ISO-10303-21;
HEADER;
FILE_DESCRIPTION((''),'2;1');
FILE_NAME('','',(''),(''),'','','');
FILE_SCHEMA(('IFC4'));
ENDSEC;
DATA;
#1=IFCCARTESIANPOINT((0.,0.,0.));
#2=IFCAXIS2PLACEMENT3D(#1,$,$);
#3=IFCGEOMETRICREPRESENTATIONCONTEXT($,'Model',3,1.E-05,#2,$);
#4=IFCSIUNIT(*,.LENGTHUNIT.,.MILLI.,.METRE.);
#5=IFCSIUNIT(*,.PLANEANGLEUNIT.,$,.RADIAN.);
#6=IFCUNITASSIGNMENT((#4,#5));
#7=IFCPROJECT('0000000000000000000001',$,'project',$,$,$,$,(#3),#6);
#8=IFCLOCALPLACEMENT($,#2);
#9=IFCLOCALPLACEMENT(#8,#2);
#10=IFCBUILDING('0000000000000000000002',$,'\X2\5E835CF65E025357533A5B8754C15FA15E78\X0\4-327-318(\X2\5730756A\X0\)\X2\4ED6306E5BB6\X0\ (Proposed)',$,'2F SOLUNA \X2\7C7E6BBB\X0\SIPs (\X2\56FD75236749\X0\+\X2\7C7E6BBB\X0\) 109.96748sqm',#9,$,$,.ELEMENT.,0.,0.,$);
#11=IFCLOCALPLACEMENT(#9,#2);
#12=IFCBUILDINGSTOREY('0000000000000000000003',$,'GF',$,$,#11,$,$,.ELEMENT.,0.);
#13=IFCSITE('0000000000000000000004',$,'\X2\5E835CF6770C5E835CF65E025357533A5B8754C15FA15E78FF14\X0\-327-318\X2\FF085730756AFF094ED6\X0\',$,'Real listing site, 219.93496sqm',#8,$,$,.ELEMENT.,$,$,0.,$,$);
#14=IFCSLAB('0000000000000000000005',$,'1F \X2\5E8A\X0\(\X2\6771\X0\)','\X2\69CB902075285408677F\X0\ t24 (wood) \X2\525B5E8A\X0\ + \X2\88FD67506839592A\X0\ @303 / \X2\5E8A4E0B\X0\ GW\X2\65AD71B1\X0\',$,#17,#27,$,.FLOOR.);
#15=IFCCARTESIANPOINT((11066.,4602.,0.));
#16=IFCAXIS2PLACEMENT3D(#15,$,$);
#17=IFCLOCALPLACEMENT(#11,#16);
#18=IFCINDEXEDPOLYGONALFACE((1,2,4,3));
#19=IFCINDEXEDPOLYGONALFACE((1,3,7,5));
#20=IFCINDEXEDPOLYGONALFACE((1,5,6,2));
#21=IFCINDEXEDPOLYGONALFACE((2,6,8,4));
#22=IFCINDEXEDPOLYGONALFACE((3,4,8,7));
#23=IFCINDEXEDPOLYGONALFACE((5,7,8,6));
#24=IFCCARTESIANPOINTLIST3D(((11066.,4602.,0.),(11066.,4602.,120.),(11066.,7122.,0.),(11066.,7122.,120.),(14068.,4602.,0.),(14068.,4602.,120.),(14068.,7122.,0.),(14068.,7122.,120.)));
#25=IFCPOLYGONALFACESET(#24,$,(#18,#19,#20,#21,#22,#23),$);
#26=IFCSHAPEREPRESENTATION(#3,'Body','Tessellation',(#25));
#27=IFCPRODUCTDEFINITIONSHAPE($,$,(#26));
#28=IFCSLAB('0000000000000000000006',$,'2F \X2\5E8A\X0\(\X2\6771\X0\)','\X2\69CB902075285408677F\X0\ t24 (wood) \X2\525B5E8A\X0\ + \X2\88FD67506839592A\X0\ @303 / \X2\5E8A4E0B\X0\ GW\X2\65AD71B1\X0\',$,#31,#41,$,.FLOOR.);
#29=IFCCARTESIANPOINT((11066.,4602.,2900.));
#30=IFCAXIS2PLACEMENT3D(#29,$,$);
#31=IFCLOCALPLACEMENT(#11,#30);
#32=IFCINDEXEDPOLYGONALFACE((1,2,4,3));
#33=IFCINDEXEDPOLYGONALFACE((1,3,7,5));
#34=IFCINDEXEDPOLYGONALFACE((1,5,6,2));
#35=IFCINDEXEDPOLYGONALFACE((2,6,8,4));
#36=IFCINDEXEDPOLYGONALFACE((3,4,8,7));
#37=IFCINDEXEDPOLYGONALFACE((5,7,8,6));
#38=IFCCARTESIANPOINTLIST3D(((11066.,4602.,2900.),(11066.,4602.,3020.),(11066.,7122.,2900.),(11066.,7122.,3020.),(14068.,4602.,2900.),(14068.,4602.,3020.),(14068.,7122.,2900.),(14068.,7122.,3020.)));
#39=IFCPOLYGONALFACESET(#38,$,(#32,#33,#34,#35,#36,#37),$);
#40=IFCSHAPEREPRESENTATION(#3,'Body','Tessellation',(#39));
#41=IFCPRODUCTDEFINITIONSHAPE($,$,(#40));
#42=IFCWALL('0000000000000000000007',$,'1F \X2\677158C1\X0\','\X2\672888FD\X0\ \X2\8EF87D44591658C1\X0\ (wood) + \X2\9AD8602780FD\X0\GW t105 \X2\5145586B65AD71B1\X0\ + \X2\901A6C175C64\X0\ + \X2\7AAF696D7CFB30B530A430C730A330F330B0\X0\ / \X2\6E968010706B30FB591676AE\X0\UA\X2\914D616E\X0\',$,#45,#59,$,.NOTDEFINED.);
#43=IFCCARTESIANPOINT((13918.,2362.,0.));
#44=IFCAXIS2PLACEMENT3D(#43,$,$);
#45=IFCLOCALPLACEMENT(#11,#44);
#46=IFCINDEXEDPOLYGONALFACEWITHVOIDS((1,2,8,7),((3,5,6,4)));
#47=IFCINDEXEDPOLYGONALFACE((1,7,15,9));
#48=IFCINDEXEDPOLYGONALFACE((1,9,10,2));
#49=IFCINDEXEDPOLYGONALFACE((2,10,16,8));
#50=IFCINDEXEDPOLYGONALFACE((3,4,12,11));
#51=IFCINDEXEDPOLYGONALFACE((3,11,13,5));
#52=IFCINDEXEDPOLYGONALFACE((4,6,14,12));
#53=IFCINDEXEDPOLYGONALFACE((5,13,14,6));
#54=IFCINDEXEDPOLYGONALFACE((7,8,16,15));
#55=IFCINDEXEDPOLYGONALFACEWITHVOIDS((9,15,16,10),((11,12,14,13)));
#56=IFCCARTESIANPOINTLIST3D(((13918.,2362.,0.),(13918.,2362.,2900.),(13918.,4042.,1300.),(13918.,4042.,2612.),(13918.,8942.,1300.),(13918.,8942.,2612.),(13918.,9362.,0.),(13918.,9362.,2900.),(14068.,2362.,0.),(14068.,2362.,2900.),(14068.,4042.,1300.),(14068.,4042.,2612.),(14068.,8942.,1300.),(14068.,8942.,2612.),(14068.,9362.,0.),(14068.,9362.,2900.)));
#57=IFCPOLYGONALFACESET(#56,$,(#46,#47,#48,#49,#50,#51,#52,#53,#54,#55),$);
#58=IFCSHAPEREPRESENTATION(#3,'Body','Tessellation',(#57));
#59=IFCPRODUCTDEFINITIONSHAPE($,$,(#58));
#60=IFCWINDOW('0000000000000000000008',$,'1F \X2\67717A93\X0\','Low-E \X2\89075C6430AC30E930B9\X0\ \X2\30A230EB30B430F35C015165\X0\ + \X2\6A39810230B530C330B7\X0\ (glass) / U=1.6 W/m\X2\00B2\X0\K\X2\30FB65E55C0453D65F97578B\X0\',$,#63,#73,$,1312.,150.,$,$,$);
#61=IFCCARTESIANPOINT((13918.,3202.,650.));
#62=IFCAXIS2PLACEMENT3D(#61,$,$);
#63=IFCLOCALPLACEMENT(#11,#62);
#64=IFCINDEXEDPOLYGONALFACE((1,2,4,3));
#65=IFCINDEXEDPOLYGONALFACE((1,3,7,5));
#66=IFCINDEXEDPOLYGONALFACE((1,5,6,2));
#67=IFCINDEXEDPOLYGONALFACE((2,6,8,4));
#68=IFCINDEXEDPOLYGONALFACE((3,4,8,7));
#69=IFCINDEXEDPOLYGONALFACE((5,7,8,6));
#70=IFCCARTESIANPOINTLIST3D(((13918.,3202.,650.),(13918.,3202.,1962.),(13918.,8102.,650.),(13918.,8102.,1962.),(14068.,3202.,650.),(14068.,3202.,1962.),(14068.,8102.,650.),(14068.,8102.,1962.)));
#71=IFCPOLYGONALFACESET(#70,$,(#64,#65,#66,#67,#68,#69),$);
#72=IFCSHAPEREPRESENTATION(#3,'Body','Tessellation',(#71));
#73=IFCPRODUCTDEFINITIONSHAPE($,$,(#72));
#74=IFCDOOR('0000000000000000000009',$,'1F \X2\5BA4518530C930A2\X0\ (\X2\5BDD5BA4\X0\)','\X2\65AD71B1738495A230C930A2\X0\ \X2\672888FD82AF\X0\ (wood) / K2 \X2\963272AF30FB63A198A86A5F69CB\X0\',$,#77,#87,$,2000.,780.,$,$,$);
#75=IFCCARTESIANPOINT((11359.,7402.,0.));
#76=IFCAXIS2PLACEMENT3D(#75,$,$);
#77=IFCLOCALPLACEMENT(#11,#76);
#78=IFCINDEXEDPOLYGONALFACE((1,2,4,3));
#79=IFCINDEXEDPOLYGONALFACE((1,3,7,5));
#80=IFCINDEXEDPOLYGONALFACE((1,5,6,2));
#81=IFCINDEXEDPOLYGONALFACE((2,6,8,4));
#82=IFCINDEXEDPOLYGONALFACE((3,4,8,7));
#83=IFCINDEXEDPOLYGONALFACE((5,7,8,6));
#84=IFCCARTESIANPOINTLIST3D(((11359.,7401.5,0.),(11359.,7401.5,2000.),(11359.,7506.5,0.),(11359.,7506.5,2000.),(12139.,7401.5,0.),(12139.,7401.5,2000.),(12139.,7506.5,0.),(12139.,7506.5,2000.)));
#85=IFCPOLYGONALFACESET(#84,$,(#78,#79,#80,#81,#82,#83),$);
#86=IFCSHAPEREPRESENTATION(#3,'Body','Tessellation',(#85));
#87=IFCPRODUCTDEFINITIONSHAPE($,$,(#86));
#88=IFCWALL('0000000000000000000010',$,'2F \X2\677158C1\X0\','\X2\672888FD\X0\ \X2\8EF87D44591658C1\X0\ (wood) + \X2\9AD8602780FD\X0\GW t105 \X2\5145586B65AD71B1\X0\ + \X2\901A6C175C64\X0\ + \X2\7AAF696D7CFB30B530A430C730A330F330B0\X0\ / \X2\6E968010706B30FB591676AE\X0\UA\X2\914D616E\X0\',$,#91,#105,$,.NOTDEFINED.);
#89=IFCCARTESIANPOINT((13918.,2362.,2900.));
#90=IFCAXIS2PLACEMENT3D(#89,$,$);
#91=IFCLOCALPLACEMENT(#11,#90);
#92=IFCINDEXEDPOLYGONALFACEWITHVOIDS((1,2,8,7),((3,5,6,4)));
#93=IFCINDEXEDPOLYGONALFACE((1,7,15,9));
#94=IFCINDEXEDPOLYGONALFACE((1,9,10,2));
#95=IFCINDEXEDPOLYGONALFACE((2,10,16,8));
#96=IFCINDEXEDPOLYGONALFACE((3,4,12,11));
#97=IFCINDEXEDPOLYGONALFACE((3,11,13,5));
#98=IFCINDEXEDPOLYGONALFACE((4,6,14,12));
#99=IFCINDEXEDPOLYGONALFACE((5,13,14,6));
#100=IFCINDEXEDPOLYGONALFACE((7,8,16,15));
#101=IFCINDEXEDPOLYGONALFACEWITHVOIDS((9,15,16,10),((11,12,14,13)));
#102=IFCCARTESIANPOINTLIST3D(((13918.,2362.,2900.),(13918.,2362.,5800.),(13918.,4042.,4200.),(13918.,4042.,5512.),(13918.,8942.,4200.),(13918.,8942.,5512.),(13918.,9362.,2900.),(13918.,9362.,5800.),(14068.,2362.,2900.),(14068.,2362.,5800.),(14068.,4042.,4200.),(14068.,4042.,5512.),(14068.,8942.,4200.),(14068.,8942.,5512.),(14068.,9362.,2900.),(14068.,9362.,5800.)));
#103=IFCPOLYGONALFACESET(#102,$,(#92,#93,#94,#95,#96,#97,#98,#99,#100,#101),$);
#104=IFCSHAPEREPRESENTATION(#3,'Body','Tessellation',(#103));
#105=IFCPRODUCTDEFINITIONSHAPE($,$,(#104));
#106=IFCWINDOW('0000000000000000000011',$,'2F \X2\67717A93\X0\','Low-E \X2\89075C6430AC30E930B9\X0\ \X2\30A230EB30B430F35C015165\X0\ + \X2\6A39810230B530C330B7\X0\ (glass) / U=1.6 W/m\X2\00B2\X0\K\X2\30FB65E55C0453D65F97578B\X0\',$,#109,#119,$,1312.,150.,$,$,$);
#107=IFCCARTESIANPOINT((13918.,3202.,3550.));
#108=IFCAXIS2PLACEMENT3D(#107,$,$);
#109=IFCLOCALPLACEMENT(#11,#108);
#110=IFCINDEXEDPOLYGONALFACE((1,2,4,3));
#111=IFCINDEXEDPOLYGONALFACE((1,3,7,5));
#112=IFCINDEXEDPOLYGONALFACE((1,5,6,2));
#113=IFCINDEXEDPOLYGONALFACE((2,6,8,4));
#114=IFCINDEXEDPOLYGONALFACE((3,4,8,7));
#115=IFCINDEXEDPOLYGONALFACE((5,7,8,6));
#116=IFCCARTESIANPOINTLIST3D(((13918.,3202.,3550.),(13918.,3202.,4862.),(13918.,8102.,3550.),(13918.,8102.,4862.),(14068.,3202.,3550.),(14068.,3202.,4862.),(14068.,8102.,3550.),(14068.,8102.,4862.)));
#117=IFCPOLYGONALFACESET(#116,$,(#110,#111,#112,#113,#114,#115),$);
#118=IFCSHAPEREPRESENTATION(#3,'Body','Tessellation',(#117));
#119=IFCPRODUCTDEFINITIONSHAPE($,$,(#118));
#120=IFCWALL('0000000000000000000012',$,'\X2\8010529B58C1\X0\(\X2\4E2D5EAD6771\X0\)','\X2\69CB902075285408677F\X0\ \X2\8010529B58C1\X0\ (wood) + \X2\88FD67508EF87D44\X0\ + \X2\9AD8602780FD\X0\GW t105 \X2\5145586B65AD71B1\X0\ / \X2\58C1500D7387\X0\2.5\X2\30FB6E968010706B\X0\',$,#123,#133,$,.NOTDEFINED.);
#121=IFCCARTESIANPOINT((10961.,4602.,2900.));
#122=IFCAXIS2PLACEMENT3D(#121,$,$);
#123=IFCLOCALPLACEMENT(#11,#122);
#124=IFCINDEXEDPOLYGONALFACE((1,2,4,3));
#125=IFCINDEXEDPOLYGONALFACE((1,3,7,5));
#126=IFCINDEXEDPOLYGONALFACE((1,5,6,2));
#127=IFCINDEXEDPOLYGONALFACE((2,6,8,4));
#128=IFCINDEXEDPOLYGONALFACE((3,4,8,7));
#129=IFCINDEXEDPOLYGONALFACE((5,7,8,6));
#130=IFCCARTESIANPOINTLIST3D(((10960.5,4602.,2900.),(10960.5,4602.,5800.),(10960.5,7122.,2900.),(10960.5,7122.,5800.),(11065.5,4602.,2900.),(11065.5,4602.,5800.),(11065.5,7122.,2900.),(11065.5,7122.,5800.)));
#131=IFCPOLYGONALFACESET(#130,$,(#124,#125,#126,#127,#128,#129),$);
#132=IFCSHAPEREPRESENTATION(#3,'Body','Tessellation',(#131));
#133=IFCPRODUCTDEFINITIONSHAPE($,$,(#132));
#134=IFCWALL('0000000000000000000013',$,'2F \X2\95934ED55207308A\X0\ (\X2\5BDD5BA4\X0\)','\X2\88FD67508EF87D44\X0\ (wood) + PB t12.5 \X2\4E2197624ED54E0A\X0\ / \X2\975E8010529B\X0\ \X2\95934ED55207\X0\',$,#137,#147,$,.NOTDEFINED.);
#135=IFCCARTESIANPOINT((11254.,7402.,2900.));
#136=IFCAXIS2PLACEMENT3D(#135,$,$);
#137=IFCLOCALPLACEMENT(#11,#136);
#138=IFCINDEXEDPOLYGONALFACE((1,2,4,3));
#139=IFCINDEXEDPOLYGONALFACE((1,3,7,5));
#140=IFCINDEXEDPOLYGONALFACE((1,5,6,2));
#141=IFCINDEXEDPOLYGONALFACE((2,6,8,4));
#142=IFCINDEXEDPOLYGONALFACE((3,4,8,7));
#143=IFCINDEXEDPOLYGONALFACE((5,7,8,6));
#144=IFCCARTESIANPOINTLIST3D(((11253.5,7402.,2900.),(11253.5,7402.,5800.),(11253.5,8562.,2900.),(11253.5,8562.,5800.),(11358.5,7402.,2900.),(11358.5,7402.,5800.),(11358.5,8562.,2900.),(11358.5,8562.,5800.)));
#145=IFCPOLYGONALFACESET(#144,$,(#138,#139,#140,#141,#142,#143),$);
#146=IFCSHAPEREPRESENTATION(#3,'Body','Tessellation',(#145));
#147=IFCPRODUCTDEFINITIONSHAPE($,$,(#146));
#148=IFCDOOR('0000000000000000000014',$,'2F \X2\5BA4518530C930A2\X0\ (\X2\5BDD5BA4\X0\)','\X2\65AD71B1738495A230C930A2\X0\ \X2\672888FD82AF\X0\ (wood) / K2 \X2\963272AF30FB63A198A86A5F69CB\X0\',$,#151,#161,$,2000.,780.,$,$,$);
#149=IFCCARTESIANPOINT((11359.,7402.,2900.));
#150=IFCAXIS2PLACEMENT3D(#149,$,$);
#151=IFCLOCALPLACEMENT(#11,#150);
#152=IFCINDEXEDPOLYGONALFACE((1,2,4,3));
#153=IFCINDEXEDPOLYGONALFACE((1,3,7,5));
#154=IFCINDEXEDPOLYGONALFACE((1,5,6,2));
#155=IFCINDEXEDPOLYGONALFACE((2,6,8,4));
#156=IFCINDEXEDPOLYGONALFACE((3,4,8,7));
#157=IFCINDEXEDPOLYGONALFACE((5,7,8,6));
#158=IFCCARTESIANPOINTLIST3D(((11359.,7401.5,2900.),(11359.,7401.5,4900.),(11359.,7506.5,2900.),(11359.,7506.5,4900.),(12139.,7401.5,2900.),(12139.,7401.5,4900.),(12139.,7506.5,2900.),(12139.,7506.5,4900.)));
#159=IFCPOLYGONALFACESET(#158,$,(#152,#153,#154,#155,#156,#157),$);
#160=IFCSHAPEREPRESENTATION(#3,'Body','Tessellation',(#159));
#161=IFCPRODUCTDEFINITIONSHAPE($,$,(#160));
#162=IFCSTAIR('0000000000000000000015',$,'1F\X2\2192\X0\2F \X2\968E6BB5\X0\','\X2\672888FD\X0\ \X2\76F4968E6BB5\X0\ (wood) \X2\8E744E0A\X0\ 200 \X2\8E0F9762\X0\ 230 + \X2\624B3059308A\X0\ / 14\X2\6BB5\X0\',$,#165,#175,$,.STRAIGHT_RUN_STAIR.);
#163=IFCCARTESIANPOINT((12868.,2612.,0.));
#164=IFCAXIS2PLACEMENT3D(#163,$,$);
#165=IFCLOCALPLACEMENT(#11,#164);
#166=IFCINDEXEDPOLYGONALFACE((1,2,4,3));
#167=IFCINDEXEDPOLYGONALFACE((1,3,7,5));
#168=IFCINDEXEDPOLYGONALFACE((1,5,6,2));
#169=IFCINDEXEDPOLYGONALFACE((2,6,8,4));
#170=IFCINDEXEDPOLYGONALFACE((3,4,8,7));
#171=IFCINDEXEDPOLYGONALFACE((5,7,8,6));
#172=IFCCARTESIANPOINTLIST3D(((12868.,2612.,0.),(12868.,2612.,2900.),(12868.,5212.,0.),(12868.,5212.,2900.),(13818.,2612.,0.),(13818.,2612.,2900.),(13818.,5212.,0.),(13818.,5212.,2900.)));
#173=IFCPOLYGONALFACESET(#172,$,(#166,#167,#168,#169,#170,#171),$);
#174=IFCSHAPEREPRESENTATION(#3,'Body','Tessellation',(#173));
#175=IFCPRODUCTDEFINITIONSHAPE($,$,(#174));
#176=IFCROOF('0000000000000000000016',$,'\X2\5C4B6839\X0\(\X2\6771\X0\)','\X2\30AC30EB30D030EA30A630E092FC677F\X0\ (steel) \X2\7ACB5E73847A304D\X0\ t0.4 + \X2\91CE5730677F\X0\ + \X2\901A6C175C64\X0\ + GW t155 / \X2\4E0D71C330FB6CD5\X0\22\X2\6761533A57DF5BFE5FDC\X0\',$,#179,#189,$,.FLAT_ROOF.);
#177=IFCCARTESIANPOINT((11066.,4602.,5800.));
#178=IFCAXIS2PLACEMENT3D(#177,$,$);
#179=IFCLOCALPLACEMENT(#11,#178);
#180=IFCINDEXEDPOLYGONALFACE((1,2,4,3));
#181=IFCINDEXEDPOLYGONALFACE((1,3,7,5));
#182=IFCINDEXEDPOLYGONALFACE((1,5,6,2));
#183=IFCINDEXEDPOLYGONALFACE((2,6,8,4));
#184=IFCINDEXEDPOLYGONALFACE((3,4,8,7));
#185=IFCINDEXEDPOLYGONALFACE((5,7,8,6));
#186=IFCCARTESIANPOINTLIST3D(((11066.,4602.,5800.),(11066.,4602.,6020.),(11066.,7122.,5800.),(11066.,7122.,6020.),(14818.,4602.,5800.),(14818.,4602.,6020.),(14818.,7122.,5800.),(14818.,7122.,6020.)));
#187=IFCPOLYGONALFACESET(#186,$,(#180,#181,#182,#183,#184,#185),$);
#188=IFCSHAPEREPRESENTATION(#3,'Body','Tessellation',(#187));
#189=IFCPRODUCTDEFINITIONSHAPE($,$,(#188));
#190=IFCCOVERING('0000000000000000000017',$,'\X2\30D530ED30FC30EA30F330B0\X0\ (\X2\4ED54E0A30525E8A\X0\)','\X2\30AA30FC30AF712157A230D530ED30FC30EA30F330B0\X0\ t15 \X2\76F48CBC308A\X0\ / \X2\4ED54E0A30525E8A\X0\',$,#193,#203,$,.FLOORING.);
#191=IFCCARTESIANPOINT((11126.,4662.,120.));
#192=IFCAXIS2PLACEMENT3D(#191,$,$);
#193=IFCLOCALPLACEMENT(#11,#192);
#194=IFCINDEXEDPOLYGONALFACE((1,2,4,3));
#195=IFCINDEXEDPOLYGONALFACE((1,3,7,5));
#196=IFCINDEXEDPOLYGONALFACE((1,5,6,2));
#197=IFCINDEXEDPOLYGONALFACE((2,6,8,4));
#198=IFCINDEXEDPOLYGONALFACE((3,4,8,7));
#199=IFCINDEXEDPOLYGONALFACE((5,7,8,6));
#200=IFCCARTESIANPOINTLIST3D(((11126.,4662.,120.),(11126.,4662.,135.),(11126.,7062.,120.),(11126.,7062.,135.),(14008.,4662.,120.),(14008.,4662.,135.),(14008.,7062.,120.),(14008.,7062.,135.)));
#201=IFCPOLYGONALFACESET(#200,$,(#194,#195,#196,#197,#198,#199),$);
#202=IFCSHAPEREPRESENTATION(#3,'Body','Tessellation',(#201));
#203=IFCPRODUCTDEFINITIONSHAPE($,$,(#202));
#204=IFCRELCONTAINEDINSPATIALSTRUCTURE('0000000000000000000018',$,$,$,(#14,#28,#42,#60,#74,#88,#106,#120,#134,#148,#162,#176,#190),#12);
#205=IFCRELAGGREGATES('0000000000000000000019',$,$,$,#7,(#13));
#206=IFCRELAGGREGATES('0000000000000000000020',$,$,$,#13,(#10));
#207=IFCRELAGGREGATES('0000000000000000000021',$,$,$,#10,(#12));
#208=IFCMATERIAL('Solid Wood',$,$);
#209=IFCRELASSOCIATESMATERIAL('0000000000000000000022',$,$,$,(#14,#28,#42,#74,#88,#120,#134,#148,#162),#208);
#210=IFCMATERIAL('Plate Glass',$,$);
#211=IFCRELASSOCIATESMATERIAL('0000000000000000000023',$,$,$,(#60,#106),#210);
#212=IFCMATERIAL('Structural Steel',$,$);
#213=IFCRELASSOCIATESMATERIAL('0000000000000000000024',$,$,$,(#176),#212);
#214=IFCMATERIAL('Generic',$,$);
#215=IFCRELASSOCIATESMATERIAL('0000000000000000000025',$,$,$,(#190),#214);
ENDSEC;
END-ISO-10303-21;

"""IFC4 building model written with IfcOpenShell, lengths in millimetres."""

from ifc_helpers import new_model, si_unit, frame, frame_2d, origin, place, context, project, spatial, rectangle, extrude, material, element, fill, save


model = new_model("IFC4")

# Units and contexts
model_context = context("Model", 3, precision=1e-05, world=origin())
ifc_project = project(units=[si_unit("LENGTHUNIT", "METRE", prefix="MILLI"), si_unit("PLANEANGLEUNIT", "RADIAN")], contexts=[model_context])

# Site, building, storey
site_placement = place(None, origin())
site = spatial("IfcSite", under=ifc_project, at=site_placement, Name="広島県広島市南区宇品御幸４-327-318（地番）他", ObjectType="Real listing site, 219.93496sqm", CompositionType="ELEMENT", RefElevation=0.0)
building_placement = place(site_placement, origin())
building = spatial("IfcBuilding", under=site, at=building_placement, Name="広島市南区宇品御幸4-327-318(地番)他の家 (Proposed)", ObjectType="2F SOLUNA 籾殻SIPs (国産杉+籾殻) 109.96748sqm", CompositionType="ELEMENT", ElevationOfRefHeight=0.0, ElevationOfTerrain=0.0)
storey_placement = place(building_placement, origin())
storey = spatial("IfcBuildingStorey", under=building, at=storey_placement, Name="GF", CompositionType="ELEMENT", Elevation=0.0)

# Slabs
ifc_material_1 = material(Name="Solid Wood")
slab_1_placement = place(storey_placement, frame((11066.0, 4602.0, 0.0)))
element("IfcSlab", 1, at=slab_1_placement, inside=storey, material=ifc_material_1, Name="1F 床(東)", Description="構造用合板 t24 (wood) 剛床 + 製材根太 @303 / 床下 GW断熱", PredefinedType="FLOOR", context=model_context, shape_type="SweptSolid", body=[
    extrude(rectangle(XDim=3002.0, YDim=2520.0, at=frame_2d((1501.0, 1260.0))), frame((11066.0, 4602.0, 0.0)), (0.0, 0.0, 1.0), 120.0),
])
slab_2_placement = place(storey_placement, frame((11066.0, 4602.0, 2900.0)))
element("IfcSlab", 2, at=slab_2_placement, inside=storey, material=ifc_material_1, Name="2F 床(東)", Description="構造用合板 t24 (wood) 剛床 + 製材根太 @303 / 床下 GW断熱", PredefinedType="FLOOR", context=model_context, shape_type="SweptSolid", body=[
    extrude(rectangle(XDim=3002.0, YDim=2520.0, at=frame_2d((1501.0, 1260.0))), frame((11066.0, 4602.0, 2900.0)), (0.0, 0.0, 1.0), 120.0),
])

# Wall, opening, window
wall_1_placement = place(storey_placement, frame((13918.0, 2362.0, 0.0)))
wall_1 = element("IfcWall", 3, at=wall_1_placement, inside=storey, material=ifc_material_1, Name="1F 東壁", Description="木製 軸組外壁 (wood) + 高性能GW t105 充填断熱 + 通気層 + 窯業系サイディング / 準耐火・外皮UA配慮", PredefinedType="NOTDEFINED", context=model_context, shape_type="SweptSolid", body=[
    extrude(rectangle(XDim=150.0, YDim=7000.0, at=frame_2d((75.0, 3500.0))), frame((13918.0, 2362.0, 0.0)), (0.0, 0.0, 1.0), 2900.0),
])
opening_1_placement = place(storey_placement, frame((13918.0, 3202.0, 650.0)))
opening_1 = element("IfcOpeningElement", 4, at=opening_1_placement, cuts=wall_1, PredefinedType="NOTDEFINED", context=model_context, shape_type="SweptSolid", body=[
    extrude(rectangle(XDim=150.0, YDim=4900.0, at=frame_2d((75.0, 2450.0))), frame((13918.0, 3202.0, 650.0)), (0.0, 0.0, 1.0), 1312.0),
])
ifc_material_2 = material(Name="Plate Glass")
window_1_placement = place(storey_placement, frame((13918.0, 3202.0, 650.0)))
window_1 = element("IfcWindow", 5, at=window_1_placement, inside=storey, material=ifc_material_2, Name="1F 東窓", Description="Low-E 複層ガラス アルゴン封入 + 樹脂サッシ (glass) / U=1.6 W/m²K・日射取得型", OverallHeight=1312.0, OverallWidth=150.0, context=model_context, shape_type="SweptSolid", body=[
    extrude(rectangle(XDim=150.0, YDim=4900.0, at=frame_2d((75.0, 2450.0))), frame((13918.0, 3202.0, 650.0)), (0.0, 0.0, 1.0), 1312.0),
])
fill(opening_1, window_1)

# Door
door_1_placement = place(storey_placement, frame((11359.0, 7402.0, 0.0)))
element("IfcDoor", 6, at=door_1_placement, inside=storey, material=ifc_material_1, Name="1F 室内ドア (寝室)", Description="断熱玄関ドア 木製芯 (wood) / K2 防犯・採風機構", OverallHeight=2000.0, OverallWidth=780.0, context=model_context, shape_type="SweptSolid", body=[
    extrude(rectangle(XDim=780.0, YDim=105.0, at=frame_2d((390.0, 52.0))), frame((11359.0, 7402.0, 0.0)), (0.0, 0.0, 1.0), 2000.0),
])

# Wall, opening, window
wall_2_placement = place(storey_placement, frame((13918.0, 2362.0, 2900.0)))
wall_2 = element("IfcWall", 7, at=wall_2_placement, inside=storey, material=ifc_material_1, Name="2F 東壁", Description="木製 軸組外壁 (wood) + 高性能GW t105 充填断熱 + 通気層 + 窯業系サイディング / 準耐火・外皮UA配慮", PredefinedType="NOTDEFINED", context=model_context, shape_type="SweptSolid", body=[
    extrude(rectangle(XDim=150.0, YDim=7000.0, at=frame_2d((75.0, 3500.0))), frame((13918.0, 2362.0, 2900.0)), (0.0, 0.0, 1.0), 2900.0),
])
opening_2_placement = place(storey_placement, frame((13918.0, 3202.0, 3550.0)))
opening_2 = element("IfcOpeningElement", 8, at=opening_2_placement, cuts=wall_2, PredefinedType="NOTDEFINED", context=model_context, shape_type="SweptSolid", body=[
    extrude(rectangle(XDim=150.0, YDim=4900.0, at=frame_2d((75.0, 2450.0))), frame((13918.0, 3202.0, 3550.0)), (0.0, 0.0, 1.0), 1312.0),
])
window_2_placement = place(storey_placement, frame((13918.0, 3202.0, 3550.0)))
window_2 = element("IfcWindow", 9, at=window_2_placement, inside=storey, material=ifc_material_2, Name="2F 東窓", Description="Low-E 複層ガラス アルゴン封入 + 樹脂サッシ (glass) / U=1.6 W/m²K・日射取得型", OverallHeight=1312.0, OverallWidth=150.0, context=model_context, shape_type="SweptSolid", body=[
    extrude(rectangle(XDim=150.0, YDim=4900.0, at=frame_2d((75.0, 2450.0))), frame((13918.0, 3202.0, 3550.0)), (0.0, 0.0, 1.0), 1312.0),
])
fill(opening_2, window_2)

# Walls
wall_3_placement = place(storey_placement, frame((10961.0, 4602.0, 2900.0)))
element("IfcWall", 10, at=wall_3_placement, inside=storey, material=ifc_material_1, Name="耐力壁(中庭東)", Description="構造用合板 耐力壁 (wood) + 製材軸組 + 高性能GW t105 充填断熱 / 壁倍率2.5・準耐火", PredefinedType="NOTDEFINED", context=model_context, shape_type="SweptSolid", body=[
    extrude(rectangle(XDim=105.0, YDim=2520.0, at=frame_2d((52.0, 1260.0))), frame((10961.0, 4602.0, 2900.0)), (0.0, 0.0, 1.0), 2900.0),
])
wall_4_placement = place(storey_placement, frame((11254.0, 7402.0, 2900.0)))
element("IfcWall", 11, at=wall_4_placement, inside=storey, material=ifc_material_1, Name="2F 間仕切り (寝室)", Description="製材軸組 (wood) + PB t12.5 両面仕上 / 非耐力 間仕切", PredefinedType="NOTDEFINED", context=model_context, shape_type="SweptSolid", body=[
    extrude(rectangle(XDim=105.0, YDim=1160.0, at=frame_2d((52.0, 580.0))), frame((11254.0, 7402.0, 2900.0)), (0.0, 0.0, 1.0), 2900.0),
])

# Door
door_2_placement = place(storey_placement, frame((11359.0, 7402.0, 2900.0)))
element("IfcDoor", 12, at=door_2_placement, inside=storey, material=ifc_material_1, Name="2F 室内ドア (寝室)", Description="断熱玄関ドア 木製芯 (wood) / K2 防犯・採風機構", OverallHeight=2000.0, OverallWidth=780.0, context=model_context, shape_type="SweptSolid", body=[
    extrude(rectangle(XDim=780.0, YDim=105.0, at=frame_2d((390.0, 52.0))), frame((11359.0, 7402.0, 2900.0)), (0.0, 0.0, 1.0), 2000.0),
])

# Stair
stair_placement = place(storey_placement, frame((12868.0, 2612.0, 0.0)))
element("IfcStair", 13, at=stair_placement, inside=storey, material=ifc_material_1, Name="1F→2F 階段", Description="木製 直階段 (wood) 蹴上 200 踏面 230 + 手すり / 14段", PredefinedType="STRAIGHT_RUN_STAIR", context=model_context, shape_type="SweptSolid", body=[
    extrude(rectangle(XDim=950.0, YDim=2600.0, at=frame_2d((475.0, 1300.0))), frame((12868.0, 2612.0, 0.0)), (0.0, 0.0, 1.0), 2900.0),
])

# Roof
ifc_material_3 = material(Name="Structural Steel")
for number, where, name in (
    (14, (11066.0, 4602.0, 5800.0), "屋根(東)"),
):
    element("IfcRoof", number, at=place(storey_placement, frame(where)), inside=storey, material=ifc_material_3, Name=name, Description="ガルバリウム鋼板 (steel) 立平葺き t0.4 + 野地板 + 通気層 + GW t155 / 不燃・法22条区域対応", PredefinedType="FLAT_ROOF", context=model_context, shape_type="SweptSolid", body=[
        extrude(rectangle(XDim=3752.0, YDim=2520.0, at=frame_2d((1876.0, 1260.0))), frame((11066.0, 4602.0, 5800.0)), (0.0, 0.0, 1.0), 220.0),
    ])

# Covering
ifc_material_4 = material(Name="Generic")
covering_1_placement = place(storey_placement, frame((11126.0, 4662.0, 120.0)))
element("IfcCovering", 15, at=covering_1_placement, inside=storey, material=ifc_material_4, Name="フローリング (仕上げ床)", Description="オーク無垢フローリング t15 直貼り / 仕上げ床", PredefinedType="FLOORING", context=model_context, shape_type="SweptSolid", body=[
    extrude(rectangle(XDim=2882.0, YDim=2400.0, at=frame_2d((1441.0, 1200.0))), frame((11126.0, 4662.0, 120.0)), (0.0, 0.0, 1.0), 15.0),
])

save(model, "model.ifc")
